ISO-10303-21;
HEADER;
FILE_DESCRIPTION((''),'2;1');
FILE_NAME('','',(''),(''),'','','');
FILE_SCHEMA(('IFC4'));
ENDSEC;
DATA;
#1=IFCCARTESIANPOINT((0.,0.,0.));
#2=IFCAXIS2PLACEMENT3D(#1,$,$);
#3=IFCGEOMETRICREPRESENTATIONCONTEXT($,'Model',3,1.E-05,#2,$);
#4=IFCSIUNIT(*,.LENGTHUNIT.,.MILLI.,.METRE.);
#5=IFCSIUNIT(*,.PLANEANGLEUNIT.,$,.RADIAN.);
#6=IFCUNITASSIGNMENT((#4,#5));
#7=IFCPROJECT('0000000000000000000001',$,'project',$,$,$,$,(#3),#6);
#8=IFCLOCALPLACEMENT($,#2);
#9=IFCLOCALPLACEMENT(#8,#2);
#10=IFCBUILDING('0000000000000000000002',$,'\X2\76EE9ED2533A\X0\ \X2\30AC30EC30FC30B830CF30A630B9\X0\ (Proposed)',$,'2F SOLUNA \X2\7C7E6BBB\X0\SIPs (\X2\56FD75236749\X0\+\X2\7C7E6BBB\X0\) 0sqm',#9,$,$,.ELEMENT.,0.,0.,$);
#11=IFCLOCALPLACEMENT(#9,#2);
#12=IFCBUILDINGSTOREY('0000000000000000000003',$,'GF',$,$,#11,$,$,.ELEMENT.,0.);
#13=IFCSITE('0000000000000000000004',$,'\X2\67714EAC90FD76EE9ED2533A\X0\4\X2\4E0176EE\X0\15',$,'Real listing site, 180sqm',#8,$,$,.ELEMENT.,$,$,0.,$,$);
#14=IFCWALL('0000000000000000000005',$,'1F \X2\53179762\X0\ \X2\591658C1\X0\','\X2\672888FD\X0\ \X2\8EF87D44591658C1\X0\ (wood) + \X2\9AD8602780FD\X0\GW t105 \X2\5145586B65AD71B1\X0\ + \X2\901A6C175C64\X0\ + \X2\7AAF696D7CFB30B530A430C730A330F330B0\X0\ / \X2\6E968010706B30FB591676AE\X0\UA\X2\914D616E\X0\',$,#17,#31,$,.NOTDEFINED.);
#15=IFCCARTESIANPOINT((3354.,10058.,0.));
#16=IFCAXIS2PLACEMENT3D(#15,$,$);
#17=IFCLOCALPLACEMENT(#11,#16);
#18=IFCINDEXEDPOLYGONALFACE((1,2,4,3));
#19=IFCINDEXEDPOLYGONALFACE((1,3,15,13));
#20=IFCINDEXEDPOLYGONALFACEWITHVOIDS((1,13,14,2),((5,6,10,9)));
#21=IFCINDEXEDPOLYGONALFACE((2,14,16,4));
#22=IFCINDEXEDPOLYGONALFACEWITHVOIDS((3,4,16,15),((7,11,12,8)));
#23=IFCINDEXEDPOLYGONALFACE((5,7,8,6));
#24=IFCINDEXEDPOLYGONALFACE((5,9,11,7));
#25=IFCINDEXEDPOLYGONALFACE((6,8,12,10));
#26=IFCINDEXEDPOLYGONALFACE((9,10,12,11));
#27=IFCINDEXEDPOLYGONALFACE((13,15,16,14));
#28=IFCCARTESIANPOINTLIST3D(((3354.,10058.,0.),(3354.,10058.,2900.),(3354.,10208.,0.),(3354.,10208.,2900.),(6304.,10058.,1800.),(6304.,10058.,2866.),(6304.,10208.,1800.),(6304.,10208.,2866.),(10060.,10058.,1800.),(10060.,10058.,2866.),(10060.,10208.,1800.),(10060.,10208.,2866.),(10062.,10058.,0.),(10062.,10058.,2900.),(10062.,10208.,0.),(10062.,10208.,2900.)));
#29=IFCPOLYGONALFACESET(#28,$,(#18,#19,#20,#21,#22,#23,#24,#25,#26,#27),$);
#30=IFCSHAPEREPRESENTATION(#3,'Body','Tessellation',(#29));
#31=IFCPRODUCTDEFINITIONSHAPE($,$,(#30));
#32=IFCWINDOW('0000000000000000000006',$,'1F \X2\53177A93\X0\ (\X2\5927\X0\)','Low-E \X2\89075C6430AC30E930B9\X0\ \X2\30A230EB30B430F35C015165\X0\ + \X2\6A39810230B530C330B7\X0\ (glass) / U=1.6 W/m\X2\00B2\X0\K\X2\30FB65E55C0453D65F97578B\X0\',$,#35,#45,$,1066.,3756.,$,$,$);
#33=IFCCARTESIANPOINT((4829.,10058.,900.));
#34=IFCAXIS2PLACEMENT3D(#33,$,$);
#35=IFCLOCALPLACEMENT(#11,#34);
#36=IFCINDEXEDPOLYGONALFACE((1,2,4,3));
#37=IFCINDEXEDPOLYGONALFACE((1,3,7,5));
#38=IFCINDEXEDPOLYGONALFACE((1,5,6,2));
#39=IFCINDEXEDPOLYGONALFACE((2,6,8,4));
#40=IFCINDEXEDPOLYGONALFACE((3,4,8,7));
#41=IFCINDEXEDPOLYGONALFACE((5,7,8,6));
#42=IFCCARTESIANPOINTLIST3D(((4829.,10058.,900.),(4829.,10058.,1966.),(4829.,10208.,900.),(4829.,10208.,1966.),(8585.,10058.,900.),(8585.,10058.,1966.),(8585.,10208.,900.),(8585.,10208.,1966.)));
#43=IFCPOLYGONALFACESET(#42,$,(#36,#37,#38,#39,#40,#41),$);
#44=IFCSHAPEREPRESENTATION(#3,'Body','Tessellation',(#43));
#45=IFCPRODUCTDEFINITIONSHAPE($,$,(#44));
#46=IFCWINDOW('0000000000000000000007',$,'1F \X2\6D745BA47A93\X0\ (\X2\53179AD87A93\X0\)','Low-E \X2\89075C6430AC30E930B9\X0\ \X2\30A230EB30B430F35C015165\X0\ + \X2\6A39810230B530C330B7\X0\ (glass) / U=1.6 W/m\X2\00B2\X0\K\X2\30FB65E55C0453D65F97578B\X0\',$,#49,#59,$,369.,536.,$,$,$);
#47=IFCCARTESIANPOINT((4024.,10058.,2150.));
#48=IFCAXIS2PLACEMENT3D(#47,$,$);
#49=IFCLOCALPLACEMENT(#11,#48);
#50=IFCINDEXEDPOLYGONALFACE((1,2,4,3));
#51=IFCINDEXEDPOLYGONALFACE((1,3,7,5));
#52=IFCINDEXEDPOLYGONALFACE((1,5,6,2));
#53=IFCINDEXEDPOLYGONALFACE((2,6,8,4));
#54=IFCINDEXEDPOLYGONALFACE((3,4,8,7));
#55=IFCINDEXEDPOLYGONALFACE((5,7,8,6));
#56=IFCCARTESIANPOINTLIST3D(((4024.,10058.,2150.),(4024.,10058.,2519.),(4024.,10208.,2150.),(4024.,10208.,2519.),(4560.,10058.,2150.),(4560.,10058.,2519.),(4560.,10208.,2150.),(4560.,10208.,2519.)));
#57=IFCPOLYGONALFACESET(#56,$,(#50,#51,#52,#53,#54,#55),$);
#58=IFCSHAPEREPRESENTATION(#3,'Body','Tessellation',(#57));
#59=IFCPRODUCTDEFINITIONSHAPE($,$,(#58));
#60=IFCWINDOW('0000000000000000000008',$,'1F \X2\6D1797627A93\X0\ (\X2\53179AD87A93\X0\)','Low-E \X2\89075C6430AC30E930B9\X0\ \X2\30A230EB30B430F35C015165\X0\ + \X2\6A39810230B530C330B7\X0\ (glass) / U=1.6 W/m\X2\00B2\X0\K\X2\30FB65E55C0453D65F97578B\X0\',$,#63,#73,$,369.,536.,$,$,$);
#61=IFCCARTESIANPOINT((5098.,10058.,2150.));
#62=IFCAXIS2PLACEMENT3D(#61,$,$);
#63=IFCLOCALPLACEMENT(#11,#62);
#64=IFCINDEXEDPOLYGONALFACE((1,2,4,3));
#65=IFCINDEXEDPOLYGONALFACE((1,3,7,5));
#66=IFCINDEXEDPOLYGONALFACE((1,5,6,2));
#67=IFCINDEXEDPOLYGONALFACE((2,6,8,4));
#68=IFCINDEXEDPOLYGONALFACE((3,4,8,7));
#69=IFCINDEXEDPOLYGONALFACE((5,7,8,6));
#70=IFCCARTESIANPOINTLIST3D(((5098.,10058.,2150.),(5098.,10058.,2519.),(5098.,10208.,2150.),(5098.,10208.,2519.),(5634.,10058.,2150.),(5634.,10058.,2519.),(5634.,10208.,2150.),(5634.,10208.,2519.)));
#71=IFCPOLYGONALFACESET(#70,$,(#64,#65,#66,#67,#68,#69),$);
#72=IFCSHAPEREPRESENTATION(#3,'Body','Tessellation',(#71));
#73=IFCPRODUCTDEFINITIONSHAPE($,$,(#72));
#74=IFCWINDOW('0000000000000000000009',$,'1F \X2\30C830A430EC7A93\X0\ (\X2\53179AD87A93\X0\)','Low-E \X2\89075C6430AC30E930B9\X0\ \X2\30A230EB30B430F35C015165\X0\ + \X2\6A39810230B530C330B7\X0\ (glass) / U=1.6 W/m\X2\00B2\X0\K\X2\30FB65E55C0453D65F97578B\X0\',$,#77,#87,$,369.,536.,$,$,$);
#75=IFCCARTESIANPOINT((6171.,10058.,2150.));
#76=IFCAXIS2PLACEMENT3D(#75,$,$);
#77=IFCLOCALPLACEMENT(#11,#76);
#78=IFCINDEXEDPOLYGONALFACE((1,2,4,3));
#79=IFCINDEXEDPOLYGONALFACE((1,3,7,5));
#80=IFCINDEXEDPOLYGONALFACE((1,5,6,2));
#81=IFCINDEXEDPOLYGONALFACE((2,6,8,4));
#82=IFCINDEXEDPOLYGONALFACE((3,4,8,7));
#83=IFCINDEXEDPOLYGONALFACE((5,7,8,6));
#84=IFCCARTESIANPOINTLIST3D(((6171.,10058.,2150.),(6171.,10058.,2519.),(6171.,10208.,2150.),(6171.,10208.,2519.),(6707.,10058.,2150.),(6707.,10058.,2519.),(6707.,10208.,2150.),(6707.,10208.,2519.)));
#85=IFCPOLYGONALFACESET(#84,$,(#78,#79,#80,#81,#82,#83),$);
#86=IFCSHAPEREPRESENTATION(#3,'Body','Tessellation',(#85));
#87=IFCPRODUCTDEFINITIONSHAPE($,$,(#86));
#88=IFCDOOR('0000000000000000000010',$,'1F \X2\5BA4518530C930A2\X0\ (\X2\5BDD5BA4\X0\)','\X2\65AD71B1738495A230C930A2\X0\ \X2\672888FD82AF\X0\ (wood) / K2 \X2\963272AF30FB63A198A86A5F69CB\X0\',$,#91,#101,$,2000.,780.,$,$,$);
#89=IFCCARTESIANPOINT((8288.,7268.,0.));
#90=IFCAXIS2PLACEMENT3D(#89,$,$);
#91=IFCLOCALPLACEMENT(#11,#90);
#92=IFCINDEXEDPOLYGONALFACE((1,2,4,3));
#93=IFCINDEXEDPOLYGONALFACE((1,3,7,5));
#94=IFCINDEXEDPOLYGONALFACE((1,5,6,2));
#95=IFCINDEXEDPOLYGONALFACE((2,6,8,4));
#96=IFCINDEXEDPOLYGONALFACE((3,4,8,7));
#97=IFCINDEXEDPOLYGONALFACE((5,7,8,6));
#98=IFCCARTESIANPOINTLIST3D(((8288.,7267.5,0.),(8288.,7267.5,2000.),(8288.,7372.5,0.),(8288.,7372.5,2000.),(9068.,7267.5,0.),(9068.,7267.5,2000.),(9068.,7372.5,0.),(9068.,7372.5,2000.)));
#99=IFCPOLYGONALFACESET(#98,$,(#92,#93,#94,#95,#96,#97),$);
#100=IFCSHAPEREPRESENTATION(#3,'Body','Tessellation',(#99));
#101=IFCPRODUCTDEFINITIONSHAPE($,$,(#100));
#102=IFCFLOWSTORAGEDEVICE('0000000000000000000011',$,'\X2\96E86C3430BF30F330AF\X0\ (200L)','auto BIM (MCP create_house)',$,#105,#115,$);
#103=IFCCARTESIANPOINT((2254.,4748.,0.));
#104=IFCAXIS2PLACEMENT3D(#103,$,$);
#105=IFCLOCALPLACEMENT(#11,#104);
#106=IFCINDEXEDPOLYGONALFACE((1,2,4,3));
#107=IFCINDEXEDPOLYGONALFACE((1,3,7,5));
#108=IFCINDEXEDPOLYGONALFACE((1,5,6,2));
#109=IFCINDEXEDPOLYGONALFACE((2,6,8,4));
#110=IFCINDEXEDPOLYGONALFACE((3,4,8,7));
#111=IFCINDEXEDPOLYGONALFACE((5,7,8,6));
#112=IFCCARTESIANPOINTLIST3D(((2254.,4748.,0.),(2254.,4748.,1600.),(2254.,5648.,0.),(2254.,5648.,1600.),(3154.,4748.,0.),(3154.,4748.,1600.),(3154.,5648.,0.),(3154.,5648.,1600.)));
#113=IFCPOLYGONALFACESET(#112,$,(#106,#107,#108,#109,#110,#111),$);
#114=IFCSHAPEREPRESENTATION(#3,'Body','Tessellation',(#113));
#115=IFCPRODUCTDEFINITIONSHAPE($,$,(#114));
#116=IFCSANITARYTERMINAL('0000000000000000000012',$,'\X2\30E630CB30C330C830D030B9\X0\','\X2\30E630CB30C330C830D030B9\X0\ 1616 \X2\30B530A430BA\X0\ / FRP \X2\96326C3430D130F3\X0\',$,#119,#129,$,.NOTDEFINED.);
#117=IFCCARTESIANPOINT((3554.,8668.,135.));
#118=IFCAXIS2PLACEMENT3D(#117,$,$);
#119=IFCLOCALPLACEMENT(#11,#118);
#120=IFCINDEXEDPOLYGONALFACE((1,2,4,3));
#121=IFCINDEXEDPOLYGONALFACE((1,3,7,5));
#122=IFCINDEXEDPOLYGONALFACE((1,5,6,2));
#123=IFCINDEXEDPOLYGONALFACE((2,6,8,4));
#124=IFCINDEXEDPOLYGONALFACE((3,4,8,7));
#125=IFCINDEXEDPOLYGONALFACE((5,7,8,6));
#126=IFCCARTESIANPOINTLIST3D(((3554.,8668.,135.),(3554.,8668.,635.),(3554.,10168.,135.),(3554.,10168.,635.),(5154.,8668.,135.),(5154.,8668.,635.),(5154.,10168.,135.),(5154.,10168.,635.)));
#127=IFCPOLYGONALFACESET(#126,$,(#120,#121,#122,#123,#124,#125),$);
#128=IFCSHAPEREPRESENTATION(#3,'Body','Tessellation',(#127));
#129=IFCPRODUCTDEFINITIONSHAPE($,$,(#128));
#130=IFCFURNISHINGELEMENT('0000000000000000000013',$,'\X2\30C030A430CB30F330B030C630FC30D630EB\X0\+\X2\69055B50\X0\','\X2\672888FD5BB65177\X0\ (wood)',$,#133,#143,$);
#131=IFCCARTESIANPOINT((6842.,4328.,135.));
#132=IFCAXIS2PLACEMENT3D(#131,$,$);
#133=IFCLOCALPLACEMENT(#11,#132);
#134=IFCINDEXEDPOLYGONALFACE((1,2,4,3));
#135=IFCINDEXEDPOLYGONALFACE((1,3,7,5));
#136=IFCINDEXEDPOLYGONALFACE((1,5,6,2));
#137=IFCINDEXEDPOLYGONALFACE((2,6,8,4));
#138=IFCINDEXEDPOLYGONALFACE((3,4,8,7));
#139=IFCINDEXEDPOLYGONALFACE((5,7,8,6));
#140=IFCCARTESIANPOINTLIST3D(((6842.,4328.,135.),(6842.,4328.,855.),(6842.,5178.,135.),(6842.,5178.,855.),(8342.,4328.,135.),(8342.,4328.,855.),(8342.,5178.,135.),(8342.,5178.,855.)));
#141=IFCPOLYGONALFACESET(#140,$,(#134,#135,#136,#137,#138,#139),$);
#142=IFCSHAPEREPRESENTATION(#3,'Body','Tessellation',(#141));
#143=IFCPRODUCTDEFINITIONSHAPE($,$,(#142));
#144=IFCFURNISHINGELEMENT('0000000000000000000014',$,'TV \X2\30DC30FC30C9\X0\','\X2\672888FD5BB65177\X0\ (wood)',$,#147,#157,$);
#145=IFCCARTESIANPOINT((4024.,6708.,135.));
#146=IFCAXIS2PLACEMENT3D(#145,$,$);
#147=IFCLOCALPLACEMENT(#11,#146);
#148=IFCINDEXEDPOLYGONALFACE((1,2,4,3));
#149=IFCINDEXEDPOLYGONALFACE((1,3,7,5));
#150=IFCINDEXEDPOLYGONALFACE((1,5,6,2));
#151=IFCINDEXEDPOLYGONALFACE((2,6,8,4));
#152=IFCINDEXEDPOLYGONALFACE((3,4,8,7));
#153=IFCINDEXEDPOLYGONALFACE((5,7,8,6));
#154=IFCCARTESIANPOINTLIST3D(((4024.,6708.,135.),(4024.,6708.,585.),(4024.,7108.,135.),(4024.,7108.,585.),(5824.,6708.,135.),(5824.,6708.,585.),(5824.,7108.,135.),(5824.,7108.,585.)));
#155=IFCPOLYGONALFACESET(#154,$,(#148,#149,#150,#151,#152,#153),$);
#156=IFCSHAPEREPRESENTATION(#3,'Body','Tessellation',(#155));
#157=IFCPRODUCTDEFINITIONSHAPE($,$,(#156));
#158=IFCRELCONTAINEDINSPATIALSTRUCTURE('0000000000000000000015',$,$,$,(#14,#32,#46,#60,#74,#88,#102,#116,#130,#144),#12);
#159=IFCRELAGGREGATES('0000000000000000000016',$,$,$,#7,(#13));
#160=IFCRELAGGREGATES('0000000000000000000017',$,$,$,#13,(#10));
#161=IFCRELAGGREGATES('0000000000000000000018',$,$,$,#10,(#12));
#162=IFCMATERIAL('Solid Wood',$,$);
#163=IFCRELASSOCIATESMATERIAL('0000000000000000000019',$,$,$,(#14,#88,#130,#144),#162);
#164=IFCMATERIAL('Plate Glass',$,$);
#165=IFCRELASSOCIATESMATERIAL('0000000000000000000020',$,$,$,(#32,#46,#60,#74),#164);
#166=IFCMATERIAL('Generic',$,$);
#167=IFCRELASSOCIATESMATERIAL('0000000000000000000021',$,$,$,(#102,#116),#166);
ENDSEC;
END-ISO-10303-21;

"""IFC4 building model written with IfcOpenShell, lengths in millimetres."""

from ifc_helpers import new_model, si_unit, frame, frame_2d, origin, place, context, project, spatial, rectangle, extrude, material, element, fill, save


model = new_model("IFC4")

# Units and contexts
model_context = context("Model", 3, precision=1e-05, world=origin())
ifc_project = project(units=[si_unit("LENGTHUNIT", "METRE", prefix="MILLI"), si_unit("PLANEANGLEUNIT", "RADIAN")], contexts=[model_context])

# Site, building, storey
site_placement = place(None, origin())
site = spatial("IfcSite", under=ifc_project, at=site_placement, Name="東京都目黒区4丁目15", ObjectType="Real listing site, 180sqm", CompositionType="ELEMENT", RefElevation=0.0)
building_placement = place(site_placement, origin())
building = spatial("IfcBuilding", under=site, at=building_placement, Name="目黒区 ガレージハウス (Proposed)", ObjectType="2F SOLUNA 籾殻SIPs (国産杉+籾殻) 0sqm", CompositionType="ELEMENT", ElevationOfRefHeight=0.0, ElevationOfTerrain=0.0)
storey_placement = place(building_placement, origin())
storey = spatial("IfcBuildingStorey", under=building, at=storey_placement, Name="GF", CompositionType="ELEMENT", Elevation=0.0)

# Wall, openings, windows
ifc_material_1 = material(Name="Solid Wood")
wall_1_placement = place(storey_placement, frame((3354.0, 10058.0, 0.0)))
wall_1 = element("IfcWall", 1, at=wall_1_placement, inside=storey, material=ifc_material_1, Name="1F 北面 外壁", Description="木製 軸組外壁 (wood) + 高性能GW t105 充填断熱 + 通気層 + 窯業系サイディング / 準耐火・外皮UA配慮", PredefinedType="NOTDEFINED", context=model_context, shape_type="SweptSolid", body=[
    extrude(rectangle(XDim=6708.0, YDim=150.0, at=frame_2d((3354.0, 75.0))), frame((3354.0, 10058.0, 0.0)), (0.0, 0.0, 1.0), 2900.0),
])
opening_1_placement = place(storey_placement, frame((4829.0, 10058.0, 900.0)))
opening_1 = element("IfcOpeningElement", 2, at=opening_1_placement, cuts=wall_1, PredefinedType="NOTDEFINED", context=model_context, shape_type="SweptSolid", body=[
    extrude(rectangle(XDim=3756.0, YDim=150.0, at=frame_2d((1878.0, 75.0))), frame((4829.0, 10058.0, 900.0)), (0.0, 0.0, 1.0), 1066.0),
])
opening_2_placement = place(storey_placement, frame((4024.0, 10058.0, 2150.0)))
opening_2 = element("IfcOpeningElement", 3, at=opening_2_placement, cuts=wall_1, PredefinedType="NOTDEFINED", context=model_context, shape_type="SweptSolid", body=[
    extrude(rectangle(XDim=536.0, YDim=150.0, at=frame_2d((268.0, 75.0))), frame((4024.0, 10058.0, 2150.0)), (0.0, 0.0, 1.0), 369.0),
])
opening_3_placement = place(storey_placement, frame((5098.0, 10058.0, 2150.0)))
opening_3 = element("IfcOpeningElement", 4, at=opening_3_placement, cuts=wall_1, PredefinedType="NOTDEFINED", context=model_context, shape_type="SweptSolid", body=[
    extrude(rectangle(XDim=536.0, YDim=150.0, at=frame_2d((268.0, 75.0))), frame((5098.0, 10058.0, 2150.0)), (0.0, 0.0, 1.0), 369.0),
])
opening_4_placement = place(storey_placement, frame((6171.0, 10058.0, 2150.0)))
opening_4 = element("IfcOpeningElement", 5, at=opening_4_placement, cuts=wall_1, PredefinedType="NOTDEFINED", context=model_context, shape_type="SweptSolid", body=[
    extrude(rectangle(XDim=536.0, YDim=150.0, at=frame_2d((268.0, 75.0))), frame((6171.0, 10058.0, 2150.0)), (0.0, 0.0, 1.0), 369.0),
])
ifc_material_2 = material(Name="Plate Glass")
window_1_placement = place(storey_placement, frame((4829.0, 10058.0, 900.0)))
window_1 = element("IfcWindow", 6, at=window_1_placement, inside=storey, material=ifc_material_2, Name="1F 北窓 (大)", Description="Low-E 複層ガラス アルゴン封入 + 樹脂サッシ (glass) / U=1.6 W/m²K・日射取得型", OverallHeight=1066.0, OverallWidth=3756.0, context=model_context, shape_type="SweptSolid", body=[
    extrude(rectangle(XDim=3756.0, YDim=150.0, at=frame_2d((1878.0, 75.0))), frame((4829.0, 10058.0, 900.0)), (0.0, 0.0, 1.0), 1066.0),
])
fill(opening_1, window_1)
window_2_placement = place(storey_placement, frame((4024.0, 10058.0, 2150.0)))
window_2 = element("IfcWindow", 7, at=window_2_placement, inside=storey, material=ifc_material_2, Name="1F 浴室窓 (北高窓)", Description="Low-E 複層ガラス アルゴン封入 + 樹脂サッシ (glass) / U=1.6 W/m²K・日射取得型", OverallHeight=369.0, OverallWidth=536.0, context=model_context, shape_type="SweptSolid", body=[
    extrude(rectangle(XDim=536.0, YDim=150.0, at=frame_2d((268.0, 75.0))), frame((4024.0, 10058.0, 2150.0)), (0.0, 0.0, 1.0), 369.0),
])
fill(opening_2, window_2)
window_3_placement = place(storey_placement, frame((5098.0, 10058.0, 2150.0)))
window_3 = element("IfcWindow", 8, at=window_3_placement, inside=storey, material=ifc_material_2, Name="1F 洗面窓 (北高窓)", Description="Low-E 複層ガラス アルゴン封入 + 樹脂サッシ (glass) / U=1.6 W/m²K・日射取得型", OverallHeight=369.0, OverallWidth=536.0, context=model_context, shape_type="SweptSolid", body=[
    extrude(rectangle(XDim=536.0, YDim=150.0, at=frame_2d((268.0, 75.0))), frame((5098.0, 10058.0, 2150.0)), (0.0, 0.0, 1.0), 369.0),
])
fill(opening_3, window_3)
window_4_placement = place(storey_placement, frame((6171.0, 10058.0, 2150.0)))
window_4 = element("IfcWindow", 9, at=window_4_placement, inside=storey, material=ifc_material_2, Name="1F トイレ窓 (北高窓)", Description="Low-E 複層ガラス アルゴン封入 + 樹脂サッシ (glass) / U=1.6 W/m²K・日射取得型", OverallHeight=369.0, OverallWidth=536.0, context=model_context, shape_type="SweptSolid", body=[
    extrude(rectangle(XDim=536.0, YDim=150.0, at=frame_2d((268.0, 75.0))), frame((6171.0, 10058.0, 2150.0)), (0.0, 0.0, 1.0), 369.0),
])
fill(opening_4, window_4)

# Door
door_1_placement = place(storey_placement, frame((8288.0, 7268.0, 0.0)))
element("IfcDoor", 10, at=door_1_placement, inside=storey, material=ifc_material_1, Name="1F 室内ドア (寝室)", Description="断熱玄関ドア 木製芯 (wood) / K2 防犯・採風機構", OverallHeight=2000.0, OverallWidth=780.0, context=model_context, shape_type="SweptSolid", body=[
    extrude(rectangle(XDim=780.0, YDim=105.0, at=frame_2d((390.0, 52.0))), frame((8288.0, 7268.0, 0.0)), (0.0, 0.0, 1.0), 2000.0),
])

# Flow storage device
ifc_material_3 = material(Name="Generic")
flow_storage_device_placement = place(storey_placement, frame((2254.0, 4748.0, 0.0)))
element("IfcFlowStorageDevice", 11, at=flow_storage_device_placement, inside=storey, material=ifc_material_3, Name="雨水タンク (200L)", Description="auto BIM (MCP create_house)", context=model_context, shape_type="SweptSolid", body=[
    extrude(rectangle(XDim=900.0, YDim=900.0, at=frame_2d((450.0, 450.0))), frame((2254.0, 4748.0, 0.0)), (0.0, 0.0, 1.0), 1600.0),
])

# Sanitary terminal
sanitary_terminal_placement = place(storey_placement, frame((3554.0, 8668.0, 135.0)))
element("IfcSanitaryTerminal", 12, at=sanitary_terminal_placement, inside=storey, material=ifc_material_3, Name="ユニットバス", Description="ユニットバス 1616 サイズ / FRP 防水パン", PredefinedType="NOTDEFINED", context=model_context, shape_type="SweptSolid", body=[
    extrude(rectangle(XDim=1600.0, YDim=1500.0, at=frame_2d((800.0, 750.0))), frame((3554.0, 8668.0, 135.0)), (0.0, 0.0, 1.0), 500.0),
])

# Furnishing elements
furnishing_1_placement = place(storey_placement, frame((6842.0, 4328.0, 135.0)))
element("IfcFurnishingElement", 13, at=furnishing_1_placement, inside=storey, material=ifc_material_1, Name="ダイニングテーブル+椅子", Description="木製家具 (wood)", context=model_context, shape_type="SweptSolid", body=[
    extrude(rectangle(XDim=1500.0, YDim=850.0, at=frame_2d((750.0, 425.0))), frame((6842.0, 4328.0, 135.0)), (0.0, 0.0, 1.0), 720.0),
])
furnishing_2_placement = place(storey_placement, frame((4024.0, 6708.0, 135.0)))
element("IfcFurnishingElement", 14, at=furnishing_2_placement, inside=storey, material=ifc_material_1, Name="TV ボード", Description="木製家具 (wood)", context=model_context, shape_type="SweptSolid", body=[
    extrude(rectangle(XDim=1800.0, YDim=400.0, at=frame_2d((900.0, 200.0))), frame((4024.0, 6708.0, 135.0)), (0.0, 0.0, 1.0), 450.0),
])

save(model, "model.ifc")
